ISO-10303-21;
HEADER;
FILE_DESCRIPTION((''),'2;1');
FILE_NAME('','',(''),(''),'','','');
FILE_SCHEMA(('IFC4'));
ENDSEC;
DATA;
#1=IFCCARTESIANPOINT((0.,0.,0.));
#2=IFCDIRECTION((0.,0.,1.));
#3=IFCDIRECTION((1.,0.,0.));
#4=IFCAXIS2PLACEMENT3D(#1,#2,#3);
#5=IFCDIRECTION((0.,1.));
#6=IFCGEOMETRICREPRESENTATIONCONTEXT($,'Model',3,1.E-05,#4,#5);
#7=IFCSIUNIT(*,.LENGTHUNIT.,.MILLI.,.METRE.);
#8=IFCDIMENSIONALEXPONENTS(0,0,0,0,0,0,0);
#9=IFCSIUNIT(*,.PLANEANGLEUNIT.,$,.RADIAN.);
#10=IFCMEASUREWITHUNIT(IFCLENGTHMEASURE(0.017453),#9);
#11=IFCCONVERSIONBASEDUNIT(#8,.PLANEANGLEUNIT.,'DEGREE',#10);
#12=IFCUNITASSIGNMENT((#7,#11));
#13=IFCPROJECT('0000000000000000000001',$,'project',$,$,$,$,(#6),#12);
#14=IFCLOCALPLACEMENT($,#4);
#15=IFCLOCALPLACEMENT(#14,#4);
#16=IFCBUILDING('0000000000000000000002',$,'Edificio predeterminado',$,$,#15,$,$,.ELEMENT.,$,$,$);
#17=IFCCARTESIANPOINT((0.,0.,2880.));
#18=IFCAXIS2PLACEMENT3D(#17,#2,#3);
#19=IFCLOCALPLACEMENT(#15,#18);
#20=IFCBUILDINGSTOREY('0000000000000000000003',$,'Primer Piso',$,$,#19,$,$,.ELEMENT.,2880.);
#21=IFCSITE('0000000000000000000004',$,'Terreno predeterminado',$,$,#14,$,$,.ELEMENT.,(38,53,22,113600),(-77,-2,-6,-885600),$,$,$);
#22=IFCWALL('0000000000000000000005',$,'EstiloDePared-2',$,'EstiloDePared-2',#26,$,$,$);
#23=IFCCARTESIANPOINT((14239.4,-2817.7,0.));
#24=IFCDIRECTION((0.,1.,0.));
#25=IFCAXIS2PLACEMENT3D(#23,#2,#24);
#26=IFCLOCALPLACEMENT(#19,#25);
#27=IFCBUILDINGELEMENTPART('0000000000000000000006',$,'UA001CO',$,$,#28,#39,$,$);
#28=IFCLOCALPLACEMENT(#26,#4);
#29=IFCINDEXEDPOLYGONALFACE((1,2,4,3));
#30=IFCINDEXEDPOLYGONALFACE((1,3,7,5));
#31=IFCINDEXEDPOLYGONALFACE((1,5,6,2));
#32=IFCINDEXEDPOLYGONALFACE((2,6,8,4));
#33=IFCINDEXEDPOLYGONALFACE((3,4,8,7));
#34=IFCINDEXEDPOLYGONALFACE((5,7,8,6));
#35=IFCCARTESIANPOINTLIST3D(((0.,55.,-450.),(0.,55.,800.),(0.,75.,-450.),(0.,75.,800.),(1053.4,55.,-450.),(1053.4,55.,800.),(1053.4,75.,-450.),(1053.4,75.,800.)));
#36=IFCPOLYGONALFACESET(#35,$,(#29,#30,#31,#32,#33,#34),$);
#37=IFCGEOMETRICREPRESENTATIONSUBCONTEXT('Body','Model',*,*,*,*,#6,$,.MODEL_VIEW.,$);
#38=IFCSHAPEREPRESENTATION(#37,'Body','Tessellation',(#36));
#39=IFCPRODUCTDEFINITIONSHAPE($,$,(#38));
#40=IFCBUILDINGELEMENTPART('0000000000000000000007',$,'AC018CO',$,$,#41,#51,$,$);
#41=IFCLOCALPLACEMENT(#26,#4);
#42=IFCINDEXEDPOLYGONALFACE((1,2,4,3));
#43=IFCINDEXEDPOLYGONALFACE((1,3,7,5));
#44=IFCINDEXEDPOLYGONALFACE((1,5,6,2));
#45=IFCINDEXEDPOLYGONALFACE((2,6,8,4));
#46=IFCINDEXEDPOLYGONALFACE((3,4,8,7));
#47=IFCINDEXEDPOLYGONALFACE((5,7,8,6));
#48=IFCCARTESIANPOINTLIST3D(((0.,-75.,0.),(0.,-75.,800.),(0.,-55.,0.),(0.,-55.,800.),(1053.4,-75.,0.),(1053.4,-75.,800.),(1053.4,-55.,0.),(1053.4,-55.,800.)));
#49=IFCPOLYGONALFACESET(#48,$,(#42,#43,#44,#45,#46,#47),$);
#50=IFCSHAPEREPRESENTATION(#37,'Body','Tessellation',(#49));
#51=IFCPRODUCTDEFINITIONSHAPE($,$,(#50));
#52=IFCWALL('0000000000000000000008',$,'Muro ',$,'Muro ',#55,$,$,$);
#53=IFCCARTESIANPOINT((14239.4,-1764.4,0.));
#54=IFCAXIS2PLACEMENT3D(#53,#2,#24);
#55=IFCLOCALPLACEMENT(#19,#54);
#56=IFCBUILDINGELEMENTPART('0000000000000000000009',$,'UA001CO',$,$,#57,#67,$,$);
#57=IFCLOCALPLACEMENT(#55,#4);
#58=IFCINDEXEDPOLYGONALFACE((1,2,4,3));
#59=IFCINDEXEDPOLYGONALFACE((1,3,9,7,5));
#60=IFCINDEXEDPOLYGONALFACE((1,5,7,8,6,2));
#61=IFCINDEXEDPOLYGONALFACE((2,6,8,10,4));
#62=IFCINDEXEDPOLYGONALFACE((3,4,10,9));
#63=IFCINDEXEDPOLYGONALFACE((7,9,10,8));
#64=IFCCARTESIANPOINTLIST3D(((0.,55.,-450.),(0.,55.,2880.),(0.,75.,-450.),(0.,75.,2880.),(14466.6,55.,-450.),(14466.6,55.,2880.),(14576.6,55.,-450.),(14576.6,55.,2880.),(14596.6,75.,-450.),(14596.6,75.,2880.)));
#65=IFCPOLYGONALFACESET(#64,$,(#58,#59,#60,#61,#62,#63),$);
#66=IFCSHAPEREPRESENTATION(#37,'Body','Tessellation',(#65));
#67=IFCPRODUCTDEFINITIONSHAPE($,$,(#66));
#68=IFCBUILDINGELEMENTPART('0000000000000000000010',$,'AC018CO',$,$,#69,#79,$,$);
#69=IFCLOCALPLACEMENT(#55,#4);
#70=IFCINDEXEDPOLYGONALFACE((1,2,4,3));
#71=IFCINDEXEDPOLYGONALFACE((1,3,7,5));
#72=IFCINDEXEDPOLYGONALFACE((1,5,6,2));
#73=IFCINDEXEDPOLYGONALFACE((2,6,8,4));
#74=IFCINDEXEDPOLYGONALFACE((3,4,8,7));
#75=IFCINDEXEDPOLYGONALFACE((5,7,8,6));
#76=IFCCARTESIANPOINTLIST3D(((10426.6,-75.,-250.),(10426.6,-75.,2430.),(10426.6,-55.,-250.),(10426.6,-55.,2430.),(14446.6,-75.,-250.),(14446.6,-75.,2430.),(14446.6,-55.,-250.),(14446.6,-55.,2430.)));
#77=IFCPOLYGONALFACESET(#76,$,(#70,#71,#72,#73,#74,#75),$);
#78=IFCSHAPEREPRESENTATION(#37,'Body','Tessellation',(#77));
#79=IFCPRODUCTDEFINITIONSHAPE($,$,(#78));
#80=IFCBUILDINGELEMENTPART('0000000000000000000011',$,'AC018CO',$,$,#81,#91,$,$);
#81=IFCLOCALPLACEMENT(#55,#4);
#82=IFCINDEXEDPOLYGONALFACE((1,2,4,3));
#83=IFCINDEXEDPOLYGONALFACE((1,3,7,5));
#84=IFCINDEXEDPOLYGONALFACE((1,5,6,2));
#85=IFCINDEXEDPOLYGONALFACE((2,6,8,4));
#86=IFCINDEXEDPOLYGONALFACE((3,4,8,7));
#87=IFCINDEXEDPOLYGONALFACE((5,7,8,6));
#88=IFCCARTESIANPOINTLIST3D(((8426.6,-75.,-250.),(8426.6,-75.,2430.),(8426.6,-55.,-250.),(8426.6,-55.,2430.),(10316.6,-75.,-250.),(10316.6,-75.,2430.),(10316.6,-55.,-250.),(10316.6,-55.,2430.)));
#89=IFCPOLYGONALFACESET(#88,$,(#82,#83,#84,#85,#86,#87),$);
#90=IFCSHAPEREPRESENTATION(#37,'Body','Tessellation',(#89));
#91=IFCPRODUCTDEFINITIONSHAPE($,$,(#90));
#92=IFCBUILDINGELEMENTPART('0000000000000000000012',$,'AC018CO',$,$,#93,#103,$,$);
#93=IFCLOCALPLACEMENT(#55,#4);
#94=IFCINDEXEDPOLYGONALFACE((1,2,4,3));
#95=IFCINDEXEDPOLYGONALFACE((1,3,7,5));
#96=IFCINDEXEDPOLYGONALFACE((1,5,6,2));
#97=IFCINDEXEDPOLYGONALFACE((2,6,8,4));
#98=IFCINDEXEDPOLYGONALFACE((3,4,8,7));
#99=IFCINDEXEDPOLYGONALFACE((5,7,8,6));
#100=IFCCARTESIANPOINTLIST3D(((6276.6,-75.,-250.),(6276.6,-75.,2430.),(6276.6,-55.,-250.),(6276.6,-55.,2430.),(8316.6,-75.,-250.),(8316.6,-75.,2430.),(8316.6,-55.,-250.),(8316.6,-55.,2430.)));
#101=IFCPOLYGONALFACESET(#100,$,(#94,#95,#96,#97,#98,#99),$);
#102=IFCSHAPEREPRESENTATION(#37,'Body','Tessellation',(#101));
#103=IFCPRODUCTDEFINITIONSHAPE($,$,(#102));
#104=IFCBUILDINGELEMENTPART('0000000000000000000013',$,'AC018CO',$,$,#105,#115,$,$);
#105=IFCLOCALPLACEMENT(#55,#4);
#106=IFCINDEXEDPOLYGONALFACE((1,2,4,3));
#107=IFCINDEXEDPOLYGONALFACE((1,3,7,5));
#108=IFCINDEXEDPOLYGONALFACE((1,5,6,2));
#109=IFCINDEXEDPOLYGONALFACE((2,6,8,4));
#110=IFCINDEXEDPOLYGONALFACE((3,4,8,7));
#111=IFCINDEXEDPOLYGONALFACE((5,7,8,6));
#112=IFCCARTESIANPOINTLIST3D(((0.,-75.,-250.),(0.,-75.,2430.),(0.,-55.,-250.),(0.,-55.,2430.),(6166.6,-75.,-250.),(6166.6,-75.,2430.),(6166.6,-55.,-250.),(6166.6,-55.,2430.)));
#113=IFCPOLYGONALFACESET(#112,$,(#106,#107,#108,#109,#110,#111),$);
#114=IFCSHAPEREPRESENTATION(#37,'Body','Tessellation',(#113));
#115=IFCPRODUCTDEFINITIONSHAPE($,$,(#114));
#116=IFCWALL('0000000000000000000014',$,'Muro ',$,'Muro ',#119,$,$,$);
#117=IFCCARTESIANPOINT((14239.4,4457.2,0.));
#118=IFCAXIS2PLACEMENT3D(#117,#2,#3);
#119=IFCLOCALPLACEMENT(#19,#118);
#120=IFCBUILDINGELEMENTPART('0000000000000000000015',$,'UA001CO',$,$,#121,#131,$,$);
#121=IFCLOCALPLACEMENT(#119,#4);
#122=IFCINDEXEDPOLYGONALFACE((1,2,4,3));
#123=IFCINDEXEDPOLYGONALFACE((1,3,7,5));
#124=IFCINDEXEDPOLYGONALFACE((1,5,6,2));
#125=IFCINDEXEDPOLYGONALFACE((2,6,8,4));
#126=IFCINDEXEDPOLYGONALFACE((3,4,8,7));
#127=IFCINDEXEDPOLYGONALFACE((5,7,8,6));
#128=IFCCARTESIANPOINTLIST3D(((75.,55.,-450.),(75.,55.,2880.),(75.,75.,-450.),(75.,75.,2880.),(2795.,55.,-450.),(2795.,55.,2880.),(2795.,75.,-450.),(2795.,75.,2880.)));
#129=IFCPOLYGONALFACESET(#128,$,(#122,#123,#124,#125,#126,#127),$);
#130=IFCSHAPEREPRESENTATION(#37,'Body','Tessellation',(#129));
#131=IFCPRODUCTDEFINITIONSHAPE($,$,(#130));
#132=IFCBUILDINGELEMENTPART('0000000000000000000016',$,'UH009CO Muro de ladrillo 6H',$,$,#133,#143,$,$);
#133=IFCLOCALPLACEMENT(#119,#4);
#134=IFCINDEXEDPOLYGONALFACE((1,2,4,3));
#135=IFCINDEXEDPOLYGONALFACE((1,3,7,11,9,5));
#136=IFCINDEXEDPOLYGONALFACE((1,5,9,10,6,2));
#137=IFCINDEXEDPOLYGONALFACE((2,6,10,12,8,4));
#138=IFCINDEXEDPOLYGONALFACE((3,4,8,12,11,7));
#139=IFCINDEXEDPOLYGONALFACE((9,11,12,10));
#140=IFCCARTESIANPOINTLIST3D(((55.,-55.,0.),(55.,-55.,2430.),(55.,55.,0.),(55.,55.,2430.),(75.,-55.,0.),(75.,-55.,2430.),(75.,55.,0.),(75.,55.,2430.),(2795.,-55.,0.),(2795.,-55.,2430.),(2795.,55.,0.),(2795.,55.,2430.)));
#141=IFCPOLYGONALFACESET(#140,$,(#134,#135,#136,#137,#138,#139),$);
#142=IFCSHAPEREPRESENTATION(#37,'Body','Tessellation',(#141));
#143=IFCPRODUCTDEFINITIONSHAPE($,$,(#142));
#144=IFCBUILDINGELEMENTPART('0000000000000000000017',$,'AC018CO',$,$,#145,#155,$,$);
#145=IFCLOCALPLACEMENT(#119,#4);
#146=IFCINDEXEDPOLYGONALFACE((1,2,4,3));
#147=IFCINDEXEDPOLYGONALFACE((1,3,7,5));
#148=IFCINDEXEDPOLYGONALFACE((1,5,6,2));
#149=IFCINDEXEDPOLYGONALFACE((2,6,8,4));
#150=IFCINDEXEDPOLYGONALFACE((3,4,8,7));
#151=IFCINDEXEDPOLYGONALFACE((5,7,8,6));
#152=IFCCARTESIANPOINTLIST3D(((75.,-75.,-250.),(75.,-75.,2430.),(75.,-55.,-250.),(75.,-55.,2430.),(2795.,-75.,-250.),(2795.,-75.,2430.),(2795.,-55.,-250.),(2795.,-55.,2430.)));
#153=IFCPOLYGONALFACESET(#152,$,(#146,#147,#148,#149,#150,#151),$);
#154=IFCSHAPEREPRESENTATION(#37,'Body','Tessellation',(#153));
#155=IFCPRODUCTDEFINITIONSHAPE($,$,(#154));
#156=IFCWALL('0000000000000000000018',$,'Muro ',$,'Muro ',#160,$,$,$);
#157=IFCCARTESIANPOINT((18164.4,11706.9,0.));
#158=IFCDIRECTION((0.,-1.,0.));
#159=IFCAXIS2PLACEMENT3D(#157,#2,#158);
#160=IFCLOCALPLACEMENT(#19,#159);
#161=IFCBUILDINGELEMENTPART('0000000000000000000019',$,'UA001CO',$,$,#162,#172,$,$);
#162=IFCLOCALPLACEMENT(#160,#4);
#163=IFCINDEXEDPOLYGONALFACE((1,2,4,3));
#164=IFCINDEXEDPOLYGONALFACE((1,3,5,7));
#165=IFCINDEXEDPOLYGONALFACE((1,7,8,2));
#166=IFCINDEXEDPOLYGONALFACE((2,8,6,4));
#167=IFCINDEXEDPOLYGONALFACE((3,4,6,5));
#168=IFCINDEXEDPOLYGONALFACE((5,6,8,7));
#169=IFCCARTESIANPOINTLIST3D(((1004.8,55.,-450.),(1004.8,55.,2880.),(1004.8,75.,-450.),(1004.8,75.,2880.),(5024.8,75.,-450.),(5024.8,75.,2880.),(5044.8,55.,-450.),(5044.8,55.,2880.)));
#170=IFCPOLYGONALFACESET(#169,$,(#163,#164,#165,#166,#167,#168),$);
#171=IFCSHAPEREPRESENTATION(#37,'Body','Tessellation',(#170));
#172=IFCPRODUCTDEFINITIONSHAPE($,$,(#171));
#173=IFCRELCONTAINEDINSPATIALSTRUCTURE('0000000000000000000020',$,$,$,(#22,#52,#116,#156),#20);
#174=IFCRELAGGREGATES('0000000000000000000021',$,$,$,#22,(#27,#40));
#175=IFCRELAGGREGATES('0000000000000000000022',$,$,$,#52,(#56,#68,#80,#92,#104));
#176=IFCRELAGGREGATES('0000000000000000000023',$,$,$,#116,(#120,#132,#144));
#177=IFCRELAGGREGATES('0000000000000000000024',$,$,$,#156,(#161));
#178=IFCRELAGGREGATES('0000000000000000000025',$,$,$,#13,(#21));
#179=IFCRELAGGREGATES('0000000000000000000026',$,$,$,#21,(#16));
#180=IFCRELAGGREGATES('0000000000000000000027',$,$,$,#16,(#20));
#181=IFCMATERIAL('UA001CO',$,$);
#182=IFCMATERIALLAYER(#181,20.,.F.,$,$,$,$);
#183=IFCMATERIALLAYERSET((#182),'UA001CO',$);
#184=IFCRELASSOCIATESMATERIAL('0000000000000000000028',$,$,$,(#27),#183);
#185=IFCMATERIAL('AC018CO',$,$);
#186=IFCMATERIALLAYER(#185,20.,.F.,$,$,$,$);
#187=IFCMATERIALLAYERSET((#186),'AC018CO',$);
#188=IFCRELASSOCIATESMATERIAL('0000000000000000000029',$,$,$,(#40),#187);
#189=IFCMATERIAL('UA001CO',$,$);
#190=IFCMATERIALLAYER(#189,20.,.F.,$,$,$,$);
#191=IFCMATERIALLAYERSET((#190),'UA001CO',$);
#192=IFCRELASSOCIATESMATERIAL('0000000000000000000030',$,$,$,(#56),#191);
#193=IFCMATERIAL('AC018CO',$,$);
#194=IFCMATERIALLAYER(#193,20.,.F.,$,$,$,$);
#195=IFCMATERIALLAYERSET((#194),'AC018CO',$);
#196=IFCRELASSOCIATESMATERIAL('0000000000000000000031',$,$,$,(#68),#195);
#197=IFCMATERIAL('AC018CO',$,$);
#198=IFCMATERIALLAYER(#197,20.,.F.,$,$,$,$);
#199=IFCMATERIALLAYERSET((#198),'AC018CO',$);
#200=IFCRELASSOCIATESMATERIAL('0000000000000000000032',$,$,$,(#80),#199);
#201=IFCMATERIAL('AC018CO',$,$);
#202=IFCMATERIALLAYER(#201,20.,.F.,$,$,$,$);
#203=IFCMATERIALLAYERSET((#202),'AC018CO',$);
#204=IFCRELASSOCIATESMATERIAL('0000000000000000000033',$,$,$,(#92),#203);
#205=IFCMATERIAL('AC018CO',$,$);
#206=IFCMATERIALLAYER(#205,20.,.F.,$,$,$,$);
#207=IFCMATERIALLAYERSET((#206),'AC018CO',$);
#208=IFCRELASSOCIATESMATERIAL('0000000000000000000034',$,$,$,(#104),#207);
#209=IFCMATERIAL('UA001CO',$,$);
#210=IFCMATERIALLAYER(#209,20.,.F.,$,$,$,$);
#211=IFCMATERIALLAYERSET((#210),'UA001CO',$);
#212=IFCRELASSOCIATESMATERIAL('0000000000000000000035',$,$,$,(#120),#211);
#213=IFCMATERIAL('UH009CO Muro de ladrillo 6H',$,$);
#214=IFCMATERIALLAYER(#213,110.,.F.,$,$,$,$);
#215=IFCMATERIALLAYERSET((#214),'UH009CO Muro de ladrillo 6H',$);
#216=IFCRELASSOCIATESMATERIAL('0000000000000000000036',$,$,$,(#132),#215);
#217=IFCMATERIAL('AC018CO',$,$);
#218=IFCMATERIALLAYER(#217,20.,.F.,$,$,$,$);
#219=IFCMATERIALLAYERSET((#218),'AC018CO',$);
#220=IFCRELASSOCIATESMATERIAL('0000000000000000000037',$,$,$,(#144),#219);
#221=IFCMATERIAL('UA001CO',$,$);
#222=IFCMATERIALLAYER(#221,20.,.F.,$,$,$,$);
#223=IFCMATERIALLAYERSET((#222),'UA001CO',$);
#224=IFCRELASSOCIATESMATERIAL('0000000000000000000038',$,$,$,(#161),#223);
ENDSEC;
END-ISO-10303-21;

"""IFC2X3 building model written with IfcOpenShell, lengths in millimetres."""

from ifc_helpers import new_model, entity, si_unit, converted_unit, direction, frame, origin_with_axes, place, context, subcontext, project, spatial, polyline, outline, extrude, material, layer, layer_set, layer_usage, element, aggregate, save


model = new_model("IFC2X3")

# Units and contexts
model_context = context("Model", 3, precision=1e-05, world=origin_with_axes(), true_north=direction((0.0, 1.0)))
body_context = subcontext(model_context, "Body", "Model", "MODEL_VIEW")
ifc_project = project(units=[si_unit("LENGTHUNIT", "METRE", prefix="MILLI"), converted_unit("PLANEANGLEUNIT", "DEGREE", entity("IfcLengthMeasure", 0.017453), si_unit("PLANEANGLEUNIT", "RADIAN"), dimensions=[0, 0, 0, 0, 0, 0, 0])], contexts=[model_context])

# Site, building, storey
site_placement = place(None, origin_with_axes())
site = spatial("IfcSite", under=ifc_project, at=site_placement, Name="Terreno predeterminado", CompositionType="ELEMENT", RefLatitude=(38, 53, 22, 113600), RefLongitude=(-77, -2, -6, -885600))
building_placement = place(site_placement, origin_with_axes())
building = spatial("IfcBuilding", under=site, at=building_placement, Name="Edificio predeterminado", CompositionType="ELEMENT")
storey_placement = place(building_placement, frame((0.0, 0.0, 2880.0), z_axis=(0.0, 0.0, 1.0), x_axis=(1.0, 0.0, 0.0)))
storey = spatial("IfcBuildingStorey", under=building, at=storey_placement, Name="Primer Piso", CompositionType="ELEMENT", Elevation=2880.0)

# Walls, building element parts
wall_1_placement = place(storey_placement, frame((14239.4, -2817.7, 0.0), z_axis=(0.0, 0.0, 1.0), x_axis=(0.0, 1.0, 0.0)))
wall_1 = element("IfcWall", 1, at=wall_1_placement, inside=storey, Name="EstiloDePared-2", ObjectType="EstiloDePared-2")
ifc_material_1 = material(Name="UA001CO")
ifc_layer_1 = layer(ifc_material_1, 20.0, ventilated=False)
ifc_layer_set_1 = layer_set([ifc_layer_1], Name="UA001CO")
ifc_layer_usage_1 = layer_usage(ifc_layer_set_1, "AXIS2", "NEGATIVE", -75.0)
building_element_part_1_placement = place(wall_1_placement, origin_with_axes())
building_element_part_1 = element("IfcBuildingElementPart", 2, at=building_element_part_1_placement, material=ifc_layer_usage_1, Name="UA001CO", context=body_context, shape_type="SweptSolid", body=[
    extrude(outline(polyline([(1053.4, 75.0), (1053.4, 55.0), (0.0, 55.0), (0.0, 75.0), (1053.4, 75.0)])), frame((0.0, 0.0, -450.0), z_axis=(0.0, 0.0, 1.0), x_axis=(1.0, 0.0, 0.0)), (0.0, 0.0, 1.0), 1250.0),
])
ifc_material_2 = material(Name="AC018CO")
ifc_layer_2 = layer(ifc_material_2, 20.0, ventilated=False)
ifc_layer_set_2 = layer_set([ifc_layer_2], Name="AC018CO")
ifc_layer_usage_2 = layer_usage(ifc_layer_set_2, "AXIS2", "NEGATIVE", 55.0)
building_element_part_2_placement = place(wall_1_placement, origin_with_axes())
building_element_part_2 = element("IfcBuildingElementPart", 3, at=building_element_part_2_placement, material=ifc_layer_usage_2, Name="AC018CO", context=body_context, shape_type="SweptSolid", body=[
    extrude(outline(polyline([(1053.4, -55.0), (1053.4, -75.0), (0.0, -75.0), (0.0, -55.0), (1053.4, -55.0)])), origin_with_axes(), (0.0, 0.0, 1.0), 800.0),
])
aggregate(wall_1, [building_element_part_1, building_element_part_2])
wall_2_placement = place(storey_placement, frame((14239.4, -1764.4, 0.0), z_axis=(0.0, 0.0, 1.0), x_axis=(0.0, 1.0, 0.0)))
wall_2 = element("IfcWall", 4, at=wall_2_placement, inside=storey, Name="Muro ", ObjectType="Muro ")
ifc_material_3 = material(Name="UA001CO")
ifc_layer_3 = layer(ifc_material_3, 20.0, ventilated=False)
ifc_layer_set_3 = layer_set([ifc_layer_3], Name="UA001CO")
ifc_layer_usage_3 = layer_usage(ifc_layer_set_3, "AXIS2", "NEGATIVE", -75.0)
building_element_part_3_placement = place(wall_2_placement, origin_with_axes())
building_element_part_3 = element("IfcBuildingElementPart", 5, at=building_element_part_3_placement, material=ifc_layer_usage_3, Name="UA001CO", context=body_context, shape_type="SweptSolid", body=[
    extrude(outline(polyline([(14596.6, 75.0), (14576.6, 55.0), (14466.6, 55.0), (0.0, 55.0), (0.0, 75.0), (14596.6, 75.0)])), frame((0.0, 0.0, -450.0), z_axis=(0.0, 0.0, 1.0), x_axis=(1.0, 0.0, 0.0)), (0.0, 0.0, 1.0), 3330.0),
])
ifc_material_4 = material(Name="AC018CO")
ifc_layer_4 = layer(ifc_material_4, 20.0, ventilated=False)
ifc_layer_set_4 = layer_set([ifc_layer_4], Name="AC018CO")
ifc_layer_usage_4 = layer_usage(ifc_layer_set_4, "AXIS2", "NEGATIVE", 55.0)
building_element_part_4_placement = place(wall_2_placement, origin_with_axes())
building_element_part_4 = element("IfcBuildingElementPart", 6, at=building_element_part_4_placement, material=ifc_layer_usage_4, Name="AC018CO", context=body_context, shape_type="SweptSolid", body=[
    extrude(outline(polyline([(14446.6, -55.0), (14446.6, -75.0), (10426.6, -75.0), (10426.6, -55.0), (14446.6, -55.0)])), frame((0.0, 0.0, -250.0), z_axis=(0.0, 0.0, 1.0), x_axis=(1.0, 0.0, 0.0)), (0.0, 0.0, 1.0), 2680.0),
])
ifc_material_5 = material(Name="AC018CO")
ifc_layer_5 = layer(ifc_material_5, 20.0, ventilated=False)
ifc_layer_set_5 = layer_set([ifc_layer_5], Name="AC018CO")
ifc_layer_usage_5 = layer_usage(ifc_layer_set_5, "AXIS2", "NEGATIVE", 55.0)
building_element_part_5_placement = place(wall_2_placement, origin_with_axes())
building_element_part_5 = element("IfcBuildingElementPart", 7, at=building_element_part_5_placement, material=ifc_layer_usage_5, Name="AC018CO", context=body_context, shape_type="SweptSolid", body=[
    extrude(outline(polyline([(10316.6, -55.0), (10316.6, -75.0), (8426.6, -75.0), (8426.6, -55.0), (10316.6, -55.0)])), frame((0.0, 0.0, -250.0), z_axis=(0.0, 0.0, 1.0), x_axis=(1.0, 0.0, 0.0)), (0.0, 0.0, 1.0), 2680.0),
])
ifc_material_6 = material(Name="AC018CO")
ifc_layer_6 = layer(ifc_material_6, 20.0, ventilated=False)
ifc_layer_set_6 = layer_set([ifc_layer_6], Name="AC018CO")
ifc_layer_usage_6 = layer_usage(ifc_layer_set_6, "AXIS2", "NEGATIVE", 55.0)
building_element_part_6_placement = place(wall_2_placement, origin_with_axes())
building_element_part_6 = element("IfcBuildingElementPart", 8, at=building_element_part_6_placement, material=ifc_layer_usage_6, Name="AC018CO", context=body_context, shape_type="SweptSolid", body=[
    extrude(outline(polyline([(8316.6, -55.0), (8316.6, -75.0), (6276.6, -75.0), (6276.6, -55.0), (8316.6, -55.0)])), frame((0.0, 0.0, -250.0), z_axis=(0.0, 0.0, 1.0), x_axis=(1.0, 0.0, 0.0)), (0.0, 0.0, 1.0), 2680.0),
])
ifc_material_7 = material(Name="AC018CO")
ifc_layer_7 = layer(ifc_material_7, 20.0, ventilated=False)
ifc_layer_set_7 = layer_set([ifc_layer_7], Name="AC018CO")
ifc_layer_usage_7 = layer_usage(ifc_layer_set_7, "AXIS2", "NEGATIVE", 55.0)
building_element_part_7_placement = place(wall_2_placement, origin_with_axes())
building_element_part_7 = element("IfcBuildingElementPart", 9, at=building_element_part_7_placement, material=ifc_layer_usage_7, Name="AC018CO", context=body_context, shape_type="SweptSolid", body=[
    extrude(outline(polyline([(6166.6, -55.0), (6166.6, -75.0), (0.0, -75.0), (0.0, -55.0), (6166.6, -55.0)])), frame((0.0, 0.0, -250.0), z_axis=(0.0, 0.0, 1.0), x_axis=(1.0, 0.0, 0.0)), (0.0, 0.0, 1.0), 2680.0),
])
aggregate(wall_2, [building_element_part_3, building_element_part_4, building_element_part_5, building_element_part_6, building_element_part_7])
wall_3_placement = place(storey_placement, frame((14239.4, 4457.2, 0.0), z_axis=(0.0, 0.0, 1.0), x_axis=(1.0, 0.0, 0.0)))
wall_3 = element("IfcWall", 10, at=wall_3_placement, inside=storey, Name="Muro ", ObjectType="Muro ")
ifc_material_8 = material(Name="UA001CO")
ifc_layer_8 = layer(ifc_material_8, 20.0, ventilated=False)
ifc_layer_set_8 = layer_set([ifc_layer_8], Name="UA001CO")
ifc_layer_usage_8 = layer_usage(ifc_layer_set_8, "AXIS2", "NEGATIVE", -75.0)
building_element_part_8_placement = place(wall_3_placement, origin_with_axes())
building_element_part_8 = element("IfcBuildingElementPart", 11, at=building_element_part_8_placement, material=ifc_layer_usage_8, Name="UA001CO", context=body_context, shape_type="SweptSolid", body=[
    extrude(outline(polyline([(2795.0, 75.0), (2795.0, 55.0), (75.0, 55.0), (75.0, 75.0), (2795.0, 75.0)])), frame((0.0, 0.0, -450.0), z_axis=(0.0, 0.0, 1.0), x_axis=(1.0, 0.0, 0.0)), (0.0, 0.0, 1.0), 3330.0),
])
ifc_material_9 = material(Name="UH009CO Muro de ladrillo 6H")
ifc_layer_9 = layer(ifc_material_9, 110.0, ventilated=False)
ifc_layer_set_9 = layer_set([ifc_layer_9], Name="UH009CO Muro de ladrillo 6H")
ifc_layer_usage_9 = layer_usage(ifc_layer_set_9, "AXIS2", "NEGATIVE", -55.0)
building_element_part_9_placement = place(wall_3_placement, origin_with_axes())
building_element_part_9 = element("IfcBuildingElementPart", 12, at=building_element_part_9_placement, material=ifc_layer_usage_9, Name="UH009CO Muro de ladrillo 6H", context=body_context, shape_type="SweptSolid", body=[
    extrude(outline(polyline([(2795.0, 55.0), (2795.0, -55.0), (75.0, -55.0), (55.0, -55.0), (55.0, 55.0), (75.0, 55.0), (2795.0, 55.0)])), origin_with_axes(), (0.0, 0.0, 1.0), 2430.0),
])
ifc_material_10 = material(Name="AC018CO")
ifc_layer_10 = layer(ifc_material_10, 20.0, ventilated=False)
ifc_layer_set_10 = layer_set([ifc_layer_10], Name="AC018CO")
ifc_layer_usage_10 = layer_usage(ifc_layer_set_10, "AXIS2", "NEGATIVE", 55.0)
building_element_part_10_placement = place(wall_3_placement, origin_with_axes())
building_element_part_10 = element("IfcBuildingElementPart", 13, at=building_element_part_10_placement, material=ifc_layer_usage_10, Name="AC018CO", context=body_context, shape_type="SweptSolid", body=[
    extrude(outline(polyline([(75.0, -55.0), (2795.0, -55.0), (2795.0, -75.0), (75.0, -75.0), (75.0, -55.0)])), frame((0.0, 0.0, -250.0), z_axis=(0.0, 0.0, 1.0), x_axis=(1.0, 0.0, 0.0)), (0.0, 0.0, 1.0), 2680.0),
])
aggregate(wall_3, [building_element_part_8, building_element_part_9, building_element_part_10])
wall_4_placement = place(storey_placement, frame((18164.4, 11706.9, 0.0), z_axis=(0.0, 0.0, 1.0), x_axis=(0.0, -1.0, 0.0)))
wall_4 = element("IfcWall", 14, at=wall_4_placement, inside=storey, Name="Muro ", ObjectType="Muro ")
ifc_material_11 = material(Name="UA001CO")
ifc_layer_11 = layer(ifc_material_11, 20.0, ventilated=False)
ifc_layer_set_11 = layer_set([ifc_layer_11], Name="UA001CO")
ifc_layer_usage_11 = layer_usage(ifc_layer_set_11, "AXIS2", "NEGATIVE", -75.0)
building_element_part_11_placement = place(wall_4_placement, origin_with_axes())
building_element_part_11 = element("IfcBuildingElementPart", 15, at=building_element_part_11_placement, material=ifc_layer_usage_11, Name="UA001CO", context=body_context, shape_type="SweptSolid", body=[
    extrude(outline(polyline([(5024.8, 75.0), (5044.8, 55.0), (1004.8, 55.0), (1004.8, 75.0), (5024.8, 75.0)])), frame((0.0, 0.0, -450.0), z_axis=(0.0, 0.0, 1.0), x_axis=(1.0, 0.0, 0.0)), (0.0, 0.0, 1.0), 3330.0),
])
aggregate(wall_4, [building_element_part_11])

save(model, "model.ifc")
